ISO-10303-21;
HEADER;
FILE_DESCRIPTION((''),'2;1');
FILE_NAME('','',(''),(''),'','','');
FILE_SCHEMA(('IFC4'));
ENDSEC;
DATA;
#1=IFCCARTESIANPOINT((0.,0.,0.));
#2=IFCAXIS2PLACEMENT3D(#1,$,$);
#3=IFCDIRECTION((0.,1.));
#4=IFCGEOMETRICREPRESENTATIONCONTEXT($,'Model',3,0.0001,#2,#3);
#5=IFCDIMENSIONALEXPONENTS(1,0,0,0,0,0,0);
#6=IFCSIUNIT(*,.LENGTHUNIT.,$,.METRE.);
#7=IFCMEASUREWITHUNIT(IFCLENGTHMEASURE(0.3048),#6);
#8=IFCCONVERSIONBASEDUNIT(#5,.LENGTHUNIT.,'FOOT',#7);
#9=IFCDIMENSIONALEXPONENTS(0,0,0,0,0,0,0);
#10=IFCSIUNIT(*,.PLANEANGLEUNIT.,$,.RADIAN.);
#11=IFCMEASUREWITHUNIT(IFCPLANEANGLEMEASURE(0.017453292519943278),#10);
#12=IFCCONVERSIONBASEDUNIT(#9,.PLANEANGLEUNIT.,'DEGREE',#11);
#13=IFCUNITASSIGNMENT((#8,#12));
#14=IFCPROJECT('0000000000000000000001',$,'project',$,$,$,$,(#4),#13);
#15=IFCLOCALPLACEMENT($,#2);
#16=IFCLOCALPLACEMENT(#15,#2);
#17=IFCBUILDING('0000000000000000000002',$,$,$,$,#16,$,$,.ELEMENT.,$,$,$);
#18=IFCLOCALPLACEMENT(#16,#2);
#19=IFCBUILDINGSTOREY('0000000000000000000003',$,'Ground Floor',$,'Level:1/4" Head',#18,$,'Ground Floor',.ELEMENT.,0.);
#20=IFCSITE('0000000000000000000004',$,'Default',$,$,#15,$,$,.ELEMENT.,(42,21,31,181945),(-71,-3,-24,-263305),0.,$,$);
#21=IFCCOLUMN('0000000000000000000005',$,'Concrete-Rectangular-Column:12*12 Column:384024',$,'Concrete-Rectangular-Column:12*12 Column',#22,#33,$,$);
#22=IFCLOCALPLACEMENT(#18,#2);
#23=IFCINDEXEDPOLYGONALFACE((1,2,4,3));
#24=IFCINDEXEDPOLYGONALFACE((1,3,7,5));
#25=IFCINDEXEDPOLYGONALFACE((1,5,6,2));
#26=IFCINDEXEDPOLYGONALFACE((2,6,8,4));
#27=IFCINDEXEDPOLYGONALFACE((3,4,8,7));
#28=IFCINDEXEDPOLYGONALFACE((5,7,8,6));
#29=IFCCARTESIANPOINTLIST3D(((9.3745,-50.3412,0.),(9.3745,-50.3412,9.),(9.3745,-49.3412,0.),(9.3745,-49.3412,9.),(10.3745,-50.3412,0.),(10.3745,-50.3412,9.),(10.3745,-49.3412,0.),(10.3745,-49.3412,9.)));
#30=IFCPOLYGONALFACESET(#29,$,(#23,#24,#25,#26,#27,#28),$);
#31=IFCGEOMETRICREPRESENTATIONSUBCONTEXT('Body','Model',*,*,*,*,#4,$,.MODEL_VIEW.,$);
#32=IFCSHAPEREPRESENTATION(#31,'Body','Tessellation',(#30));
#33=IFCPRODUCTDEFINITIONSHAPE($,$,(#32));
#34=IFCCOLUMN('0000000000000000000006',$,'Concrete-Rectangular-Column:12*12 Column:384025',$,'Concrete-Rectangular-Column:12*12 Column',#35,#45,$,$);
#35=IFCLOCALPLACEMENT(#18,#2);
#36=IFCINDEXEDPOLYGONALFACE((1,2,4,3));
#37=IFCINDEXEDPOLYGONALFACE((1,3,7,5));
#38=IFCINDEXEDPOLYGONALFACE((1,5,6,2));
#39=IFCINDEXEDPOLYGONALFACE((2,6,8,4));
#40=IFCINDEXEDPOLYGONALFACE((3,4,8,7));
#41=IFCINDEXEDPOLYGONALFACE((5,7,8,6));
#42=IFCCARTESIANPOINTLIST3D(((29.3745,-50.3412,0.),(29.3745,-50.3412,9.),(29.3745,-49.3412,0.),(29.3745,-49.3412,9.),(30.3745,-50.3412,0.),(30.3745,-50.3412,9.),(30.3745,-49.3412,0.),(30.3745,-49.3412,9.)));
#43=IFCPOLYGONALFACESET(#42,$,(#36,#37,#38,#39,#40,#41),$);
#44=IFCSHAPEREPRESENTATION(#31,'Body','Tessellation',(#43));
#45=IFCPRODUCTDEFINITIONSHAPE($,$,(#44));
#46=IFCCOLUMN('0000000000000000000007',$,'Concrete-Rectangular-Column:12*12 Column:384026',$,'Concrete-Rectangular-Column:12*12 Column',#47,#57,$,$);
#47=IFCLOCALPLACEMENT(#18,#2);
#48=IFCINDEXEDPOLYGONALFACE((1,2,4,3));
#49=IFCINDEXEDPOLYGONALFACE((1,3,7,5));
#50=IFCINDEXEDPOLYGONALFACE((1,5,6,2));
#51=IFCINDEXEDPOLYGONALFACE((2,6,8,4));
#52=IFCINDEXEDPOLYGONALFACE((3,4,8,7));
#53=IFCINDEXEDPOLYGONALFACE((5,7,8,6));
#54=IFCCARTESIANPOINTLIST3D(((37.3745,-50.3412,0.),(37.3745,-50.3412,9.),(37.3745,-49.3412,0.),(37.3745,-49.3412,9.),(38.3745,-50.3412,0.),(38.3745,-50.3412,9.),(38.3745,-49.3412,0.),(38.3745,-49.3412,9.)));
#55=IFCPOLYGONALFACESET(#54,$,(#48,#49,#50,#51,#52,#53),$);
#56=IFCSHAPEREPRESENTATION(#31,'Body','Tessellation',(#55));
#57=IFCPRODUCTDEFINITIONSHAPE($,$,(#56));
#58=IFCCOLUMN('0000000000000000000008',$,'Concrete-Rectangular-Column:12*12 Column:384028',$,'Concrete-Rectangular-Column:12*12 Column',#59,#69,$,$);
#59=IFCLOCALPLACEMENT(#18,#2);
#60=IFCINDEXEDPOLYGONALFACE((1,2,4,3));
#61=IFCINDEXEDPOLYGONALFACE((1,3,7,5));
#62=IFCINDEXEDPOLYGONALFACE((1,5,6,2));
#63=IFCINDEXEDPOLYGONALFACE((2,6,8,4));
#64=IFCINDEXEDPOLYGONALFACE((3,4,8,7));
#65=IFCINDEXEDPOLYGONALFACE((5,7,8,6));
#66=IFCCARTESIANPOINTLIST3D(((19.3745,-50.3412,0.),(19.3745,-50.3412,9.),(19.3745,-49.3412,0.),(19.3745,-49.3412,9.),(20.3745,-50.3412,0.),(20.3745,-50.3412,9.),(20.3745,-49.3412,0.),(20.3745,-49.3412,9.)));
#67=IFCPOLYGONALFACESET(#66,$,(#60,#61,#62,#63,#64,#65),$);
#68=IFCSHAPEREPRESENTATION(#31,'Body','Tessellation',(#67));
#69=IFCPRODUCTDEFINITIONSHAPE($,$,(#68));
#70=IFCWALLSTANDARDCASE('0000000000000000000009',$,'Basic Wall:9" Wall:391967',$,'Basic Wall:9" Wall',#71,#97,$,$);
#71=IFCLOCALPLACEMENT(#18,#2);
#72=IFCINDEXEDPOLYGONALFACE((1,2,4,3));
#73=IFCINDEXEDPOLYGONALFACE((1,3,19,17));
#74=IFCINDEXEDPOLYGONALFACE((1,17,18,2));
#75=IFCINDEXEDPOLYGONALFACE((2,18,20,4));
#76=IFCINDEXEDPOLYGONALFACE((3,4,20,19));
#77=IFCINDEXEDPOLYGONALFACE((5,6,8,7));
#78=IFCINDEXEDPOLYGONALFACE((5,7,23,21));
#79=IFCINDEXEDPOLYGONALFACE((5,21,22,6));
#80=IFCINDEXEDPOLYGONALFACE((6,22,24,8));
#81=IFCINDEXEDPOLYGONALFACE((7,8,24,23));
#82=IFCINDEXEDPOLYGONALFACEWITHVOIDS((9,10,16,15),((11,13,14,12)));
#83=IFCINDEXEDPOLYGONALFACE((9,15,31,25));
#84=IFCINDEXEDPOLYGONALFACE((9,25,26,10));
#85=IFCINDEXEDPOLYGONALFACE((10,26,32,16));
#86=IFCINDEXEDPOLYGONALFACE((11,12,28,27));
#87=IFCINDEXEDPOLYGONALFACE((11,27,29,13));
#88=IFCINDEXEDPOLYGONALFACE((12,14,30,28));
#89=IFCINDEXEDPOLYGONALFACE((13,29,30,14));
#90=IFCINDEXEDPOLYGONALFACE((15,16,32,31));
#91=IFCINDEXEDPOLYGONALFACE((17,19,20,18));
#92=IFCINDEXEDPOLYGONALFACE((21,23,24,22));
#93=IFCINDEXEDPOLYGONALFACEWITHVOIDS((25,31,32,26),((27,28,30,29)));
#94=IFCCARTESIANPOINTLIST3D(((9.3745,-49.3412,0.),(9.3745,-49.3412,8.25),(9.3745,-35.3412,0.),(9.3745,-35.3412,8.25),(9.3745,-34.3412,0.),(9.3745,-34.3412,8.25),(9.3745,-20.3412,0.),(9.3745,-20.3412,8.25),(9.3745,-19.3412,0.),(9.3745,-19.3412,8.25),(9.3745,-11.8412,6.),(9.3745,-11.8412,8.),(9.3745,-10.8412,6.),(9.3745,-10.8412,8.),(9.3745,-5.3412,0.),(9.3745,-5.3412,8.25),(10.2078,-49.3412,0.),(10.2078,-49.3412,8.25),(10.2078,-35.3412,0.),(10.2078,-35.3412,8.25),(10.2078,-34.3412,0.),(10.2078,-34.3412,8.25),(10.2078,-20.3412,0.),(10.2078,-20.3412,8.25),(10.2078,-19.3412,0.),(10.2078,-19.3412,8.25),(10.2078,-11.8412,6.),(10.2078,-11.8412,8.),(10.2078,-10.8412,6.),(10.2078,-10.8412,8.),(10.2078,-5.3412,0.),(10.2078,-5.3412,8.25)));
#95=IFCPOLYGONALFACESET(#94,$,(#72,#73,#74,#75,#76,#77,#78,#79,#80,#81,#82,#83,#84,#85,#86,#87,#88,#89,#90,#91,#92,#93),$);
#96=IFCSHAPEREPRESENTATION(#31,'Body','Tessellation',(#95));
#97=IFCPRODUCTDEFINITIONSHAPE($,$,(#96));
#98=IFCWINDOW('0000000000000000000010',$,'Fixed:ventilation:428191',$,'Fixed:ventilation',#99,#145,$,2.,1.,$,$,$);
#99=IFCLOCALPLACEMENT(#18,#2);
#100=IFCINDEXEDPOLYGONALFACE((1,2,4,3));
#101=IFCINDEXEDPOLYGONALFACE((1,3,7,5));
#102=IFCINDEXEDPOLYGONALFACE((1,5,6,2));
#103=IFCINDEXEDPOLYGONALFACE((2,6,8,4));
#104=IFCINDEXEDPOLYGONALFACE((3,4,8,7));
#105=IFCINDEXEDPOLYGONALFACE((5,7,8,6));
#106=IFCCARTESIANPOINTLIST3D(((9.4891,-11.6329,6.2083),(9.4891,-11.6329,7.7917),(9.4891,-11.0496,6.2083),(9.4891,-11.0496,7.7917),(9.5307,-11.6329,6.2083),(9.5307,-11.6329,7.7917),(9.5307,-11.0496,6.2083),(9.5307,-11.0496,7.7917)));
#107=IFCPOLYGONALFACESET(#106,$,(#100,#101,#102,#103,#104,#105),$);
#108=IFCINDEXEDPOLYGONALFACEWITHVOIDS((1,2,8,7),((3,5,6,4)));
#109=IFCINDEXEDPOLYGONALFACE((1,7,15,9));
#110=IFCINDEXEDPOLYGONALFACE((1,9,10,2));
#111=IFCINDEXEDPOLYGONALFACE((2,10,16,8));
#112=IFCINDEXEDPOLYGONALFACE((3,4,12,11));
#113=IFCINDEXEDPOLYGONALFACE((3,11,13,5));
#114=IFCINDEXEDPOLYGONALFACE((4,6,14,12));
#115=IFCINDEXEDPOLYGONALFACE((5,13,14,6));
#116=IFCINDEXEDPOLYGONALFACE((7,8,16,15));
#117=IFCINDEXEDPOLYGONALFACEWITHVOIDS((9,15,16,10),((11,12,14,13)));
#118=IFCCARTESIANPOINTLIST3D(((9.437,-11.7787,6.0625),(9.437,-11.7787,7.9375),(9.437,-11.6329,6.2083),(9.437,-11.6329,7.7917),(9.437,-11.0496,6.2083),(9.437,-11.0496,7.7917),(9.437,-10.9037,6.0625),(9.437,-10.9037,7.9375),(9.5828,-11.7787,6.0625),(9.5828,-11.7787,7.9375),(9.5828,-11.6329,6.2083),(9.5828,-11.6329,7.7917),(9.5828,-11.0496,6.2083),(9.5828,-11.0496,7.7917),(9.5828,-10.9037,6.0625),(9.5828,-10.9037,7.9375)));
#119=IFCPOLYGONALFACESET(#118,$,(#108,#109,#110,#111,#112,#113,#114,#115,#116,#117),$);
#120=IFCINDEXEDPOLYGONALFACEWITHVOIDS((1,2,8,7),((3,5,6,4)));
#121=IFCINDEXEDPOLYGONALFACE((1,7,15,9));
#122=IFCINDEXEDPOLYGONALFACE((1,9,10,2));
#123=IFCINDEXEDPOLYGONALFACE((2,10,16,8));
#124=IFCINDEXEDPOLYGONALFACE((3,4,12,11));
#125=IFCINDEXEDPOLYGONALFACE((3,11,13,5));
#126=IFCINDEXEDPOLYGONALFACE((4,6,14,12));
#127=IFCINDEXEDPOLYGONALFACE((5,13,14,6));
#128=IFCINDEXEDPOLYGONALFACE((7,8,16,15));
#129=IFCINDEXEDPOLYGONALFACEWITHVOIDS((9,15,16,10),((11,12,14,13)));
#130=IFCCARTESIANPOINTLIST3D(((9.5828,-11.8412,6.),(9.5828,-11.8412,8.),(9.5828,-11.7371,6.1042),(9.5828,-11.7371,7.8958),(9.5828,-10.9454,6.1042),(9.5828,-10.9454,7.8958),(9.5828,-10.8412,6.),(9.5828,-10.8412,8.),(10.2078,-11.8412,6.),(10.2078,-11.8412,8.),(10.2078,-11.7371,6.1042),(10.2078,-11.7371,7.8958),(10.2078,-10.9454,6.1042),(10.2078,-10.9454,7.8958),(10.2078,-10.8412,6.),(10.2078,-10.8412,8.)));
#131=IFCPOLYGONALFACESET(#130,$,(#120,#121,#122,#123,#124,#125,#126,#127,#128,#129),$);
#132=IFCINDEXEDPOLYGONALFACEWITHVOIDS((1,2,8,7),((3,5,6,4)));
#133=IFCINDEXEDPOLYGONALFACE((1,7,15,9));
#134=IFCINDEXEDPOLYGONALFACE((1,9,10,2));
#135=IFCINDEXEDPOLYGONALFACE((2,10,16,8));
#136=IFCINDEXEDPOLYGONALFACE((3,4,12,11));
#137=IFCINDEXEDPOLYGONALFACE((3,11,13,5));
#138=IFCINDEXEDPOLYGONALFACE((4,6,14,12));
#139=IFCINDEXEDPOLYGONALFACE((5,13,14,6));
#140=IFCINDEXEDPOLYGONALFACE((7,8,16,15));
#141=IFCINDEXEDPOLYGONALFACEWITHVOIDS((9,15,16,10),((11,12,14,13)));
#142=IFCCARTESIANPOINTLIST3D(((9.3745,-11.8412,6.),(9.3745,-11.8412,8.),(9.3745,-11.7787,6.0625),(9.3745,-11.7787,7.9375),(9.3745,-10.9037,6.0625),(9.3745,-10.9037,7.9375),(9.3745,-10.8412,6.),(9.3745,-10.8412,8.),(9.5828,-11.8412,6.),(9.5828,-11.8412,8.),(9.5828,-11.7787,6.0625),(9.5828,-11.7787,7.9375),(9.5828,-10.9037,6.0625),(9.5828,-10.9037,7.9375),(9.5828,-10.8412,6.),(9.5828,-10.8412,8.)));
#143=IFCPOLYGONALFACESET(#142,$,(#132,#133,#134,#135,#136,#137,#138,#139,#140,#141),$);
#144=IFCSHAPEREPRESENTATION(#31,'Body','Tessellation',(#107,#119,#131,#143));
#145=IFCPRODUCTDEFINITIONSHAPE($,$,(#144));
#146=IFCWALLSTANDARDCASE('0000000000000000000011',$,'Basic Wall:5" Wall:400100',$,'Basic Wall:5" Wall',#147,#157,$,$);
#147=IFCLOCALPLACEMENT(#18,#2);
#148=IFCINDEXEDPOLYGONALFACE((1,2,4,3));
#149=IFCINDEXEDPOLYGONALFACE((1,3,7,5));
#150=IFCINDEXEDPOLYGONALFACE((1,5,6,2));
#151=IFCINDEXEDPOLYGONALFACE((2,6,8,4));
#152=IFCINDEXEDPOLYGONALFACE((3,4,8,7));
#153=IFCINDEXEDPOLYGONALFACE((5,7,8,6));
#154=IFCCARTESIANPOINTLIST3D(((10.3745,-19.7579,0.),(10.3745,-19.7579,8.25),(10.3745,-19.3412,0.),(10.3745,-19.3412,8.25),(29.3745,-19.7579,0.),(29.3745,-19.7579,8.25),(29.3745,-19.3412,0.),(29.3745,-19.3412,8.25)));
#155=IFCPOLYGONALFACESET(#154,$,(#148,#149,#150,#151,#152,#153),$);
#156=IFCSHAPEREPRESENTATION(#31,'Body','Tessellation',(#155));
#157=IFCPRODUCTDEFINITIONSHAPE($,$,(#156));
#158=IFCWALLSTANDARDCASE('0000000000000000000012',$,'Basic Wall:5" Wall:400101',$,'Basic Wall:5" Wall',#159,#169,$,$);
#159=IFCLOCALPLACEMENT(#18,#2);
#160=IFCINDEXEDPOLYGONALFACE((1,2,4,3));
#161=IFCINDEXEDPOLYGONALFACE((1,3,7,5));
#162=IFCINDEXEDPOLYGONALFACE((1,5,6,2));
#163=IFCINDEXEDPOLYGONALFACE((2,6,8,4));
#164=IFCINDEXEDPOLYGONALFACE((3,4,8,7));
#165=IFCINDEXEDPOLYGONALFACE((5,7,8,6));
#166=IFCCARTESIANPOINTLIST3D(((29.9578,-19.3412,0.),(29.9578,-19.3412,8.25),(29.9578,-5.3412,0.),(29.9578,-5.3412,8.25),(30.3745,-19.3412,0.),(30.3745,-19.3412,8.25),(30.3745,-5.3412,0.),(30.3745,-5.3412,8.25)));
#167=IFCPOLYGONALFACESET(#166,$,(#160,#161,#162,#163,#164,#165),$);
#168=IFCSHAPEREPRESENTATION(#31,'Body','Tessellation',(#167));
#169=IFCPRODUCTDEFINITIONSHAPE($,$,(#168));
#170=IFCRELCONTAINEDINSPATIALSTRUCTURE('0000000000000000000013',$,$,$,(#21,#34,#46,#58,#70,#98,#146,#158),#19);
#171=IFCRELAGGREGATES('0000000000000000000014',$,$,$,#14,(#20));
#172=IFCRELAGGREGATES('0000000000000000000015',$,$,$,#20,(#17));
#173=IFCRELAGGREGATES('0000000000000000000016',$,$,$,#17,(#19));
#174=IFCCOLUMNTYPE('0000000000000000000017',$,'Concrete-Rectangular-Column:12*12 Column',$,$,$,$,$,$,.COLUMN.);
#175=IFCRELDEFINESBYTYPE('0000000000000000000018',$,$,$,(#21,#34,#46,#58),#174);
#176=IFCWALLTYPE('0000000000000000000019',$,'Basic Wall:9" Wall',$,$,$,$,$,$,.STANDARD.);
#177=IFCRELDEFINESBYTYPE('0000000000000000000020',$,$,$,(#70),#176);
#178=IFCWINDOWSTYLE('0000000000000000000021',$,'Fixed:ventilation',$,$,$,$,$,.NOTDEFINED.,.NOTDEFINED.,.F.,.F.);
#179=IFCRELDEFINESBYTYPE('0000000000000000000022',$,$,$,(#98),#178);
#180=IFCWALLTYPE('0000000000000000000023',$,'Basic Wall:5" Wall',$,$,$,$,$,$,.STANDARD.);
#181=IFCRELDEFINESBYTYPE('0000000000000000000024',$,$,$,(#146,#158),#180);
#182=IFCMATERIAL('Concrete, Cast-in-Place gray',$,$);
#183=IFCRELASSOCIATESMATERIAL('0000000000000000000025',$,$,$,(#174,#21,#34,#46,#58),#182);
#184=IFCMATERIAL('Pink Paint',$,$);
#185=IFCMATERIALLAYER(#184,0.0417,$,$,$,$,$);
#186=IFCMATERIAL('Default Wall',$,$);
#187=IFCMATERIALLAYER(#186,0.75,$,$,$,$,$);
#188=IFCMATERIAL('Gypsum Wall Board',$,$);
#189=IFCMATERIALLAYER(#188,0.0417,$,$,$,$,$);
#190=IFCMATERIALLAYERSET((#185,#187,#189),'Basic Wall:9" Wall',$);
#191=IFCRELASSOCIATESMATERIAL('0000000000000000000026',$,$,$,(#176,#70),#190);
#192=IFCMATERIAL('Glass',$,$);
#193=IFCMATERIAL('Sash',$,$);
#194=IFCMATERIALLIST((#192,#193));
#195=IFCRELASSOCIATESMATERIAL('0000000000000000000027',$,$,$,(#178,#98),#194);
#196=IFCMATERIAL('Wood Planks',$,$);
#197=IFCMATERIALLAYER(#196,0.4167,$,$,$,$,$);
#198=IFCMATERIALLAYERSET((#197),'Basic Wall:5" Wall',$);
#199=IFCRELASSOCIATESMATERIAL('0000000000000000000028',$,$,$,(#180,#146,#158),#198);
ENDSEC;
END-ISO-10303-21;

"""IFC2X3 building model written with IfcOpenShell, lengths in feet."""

from ifc_helpers import new_model, entity, si_unit, converted_unit, direction, frame, frame_2d, origin, origin_2d_with_axis, place, context, subcontext, project, spatial, polyline, rectangle, outline, extrude, clip, bounded_halfspace, source, transform, mapped, material, material_list, layer, layer_set, layer_usage, type_object, type_shapes, element, fill, save


model = new_model("IFC2X3")

# Units and contexts
model_context = context("Model", 3, precision=0.0001, world=origin(), true_north=direction((0.0, 1.0)))
body_context = subcontext(model_context, "Body", "Model", "MODEL_VIEW")
ifc_project = project(units=[converted_unit("LENGTHUNIT", "FOOT", entity("IfcLengthMeasure", 0.3048), si_unit("LENGTHUNIT", "METRE"), dimensions=[1, 0, 0, 0, 0, 0, 0]), converted_unit("PLANEANGLEUNIT", "DEGREE", entity("IfcPlaneAngleMeasure", 0.017453292519943278), si_unit("PLANEANGLEUNIT", "RADIAN"), dimensions=[0, 0, 0, 0, 0, 0, 0])], contexts=[model_context])

# Site, building, storey
site_placement = place(None, origin())
site = spatial("IfcSite", under=ifc_project, at=site_placement, Name="Default", CompositionType="ELEMENT", RefLatitude=(42, 21, 31, 181945), RefLongitude=(-71, -3, -24, -263305), RefElevation=0.0)
building_placement = place(site_placement, origin())
building = spatial("IfcBuilding", under=site, at=building_placement, CompositionType="ELEMENT")
storey_placement = place(building_placement, origin())
storey = spatial("IfcBuildingStorey", under=building, at=storey_placement, Name="Ground Floor", ObjectType="Level:1/4\" Head", LongName="Ground Floor", CompositionType="ELEMENT", Elevation=0.0)

# Columns
ifc_material_1 = material(Name="Concrete, Cast-in-Place gray")
column_type = type_object("IfcColumnType", Name="Concrete-Rectangular-Column:12*12 Column", PredefinedType="COLUMN", material=ifc_material_1)
shared_shape_1 = source(origin(), body_context, "Body", "SweptSolid", [
    extrude(rectangle(XDim=1.0, YDim=1.0, at=origin_2d_with_axis()), frame((0.0, 0.0, 0.0), z_axis=(0.0, 0.0, 1.0), x_axis=(-1.0, 0.0, 0.0)), (0.0, 0.0, 1.0), 9.0),
])
type_shapes(column_type, [shared_shape_1])
for number, where, name in (
    (1, (9.8745, -49.8412, 0.0), "Concrete-Rectangular-Column:12*12 Column:384024"),
    (2, (29.8745, -49.8412, 0.0), "Concrete-Rectangular-Column:12*12 Column:384025"),
    (3, (37.8745, -49.8412, 0.0), "Concrete-Rectangular-Column:12*12 Column:384026"),
    (4, (19.8745, -49.8412, 0.0), "Concrete-Rectangular-Column:12*12 Column:384028"),
):
    element("IfcColumn", number, at=place(storey_placement, frame(where)), inside=storey, type_object=column_type, material=ifc_material_1, Name=name, ObjectType="Concrete-Rectangular-Column:12*12 Column", context=body_context, shape_type="MappedRepresentation", body=[
        mapped(shared_shape_1, transform((0.0, 0.0, 0.0), scale=1.0)),
    ])

# Wall, openings, window
ifc_material_2 = material(Name="Pink Paint")
ifc_layer_1 = layer(ifc_material_2, 0.0417)
ifc_material_3 = material(Name="Default Wall")
ifc_layer_2 = layer(ifc_material_3, 0.75)
ifc_material_4 = material(Name="Gypsum Wall Board")
ifc_layer_3 = layer(ifc_material_4, 0.0417)
ifc_layer_set_1 = layer_set([ifc_layer_1, ifc_layer_2, ifc_layer_3], Name="Basic Wall:9\" Wall")
ifc_layer_usage_1 = layer_usage(ifc_layer_set_1, "AXIS2", "NEGATIVE", 0.4167)
wall_type_1 = type_object("IfcWallType", Name="Basic Wall:9\" Wall", PredefinedType="STANDARD", material=ifc_layer_set_1)
wall_1_placement = place(storey_placement, frame((9.7911, -49.3412, 0.0), z_axis=(0.0, 0.0, 1.0), x_axis=(0.0, 1.0, 0.0)))
wall_1 = element("IfcWallStandardCase", 5, at=wall_1_placement, inside=storey, type_object=wall_type_1, material=ifc_layer_usage_1, Name="Basic Wall:9\" Wall:391967", ObjectType="Basic Wall:9\" Wall", context=body_context, shape_type="Clipping", body=[
    clip(clip(clip(clip(clip(extrude(rectangle(XDim=44.0, YDim=0.8333, at=frame_2d((22.0, 0.0), x_axis=(-1.0, 0.0))), origin(), (0.0, 0.0, 1.0), 8.25), bounded_halfspace(frame((0.0, 0.4167, 0.0), z_axis=(1.0, 0.0, 0.0), x_axis=(0.0, 0.0, -1.0)), True, frame((0.0, 0.4167, 0.0), z_axis=(1.0, 0.0, 0.0), x_axis=(0.0, 0.0, -1.0)), polyline([(0.0, 0.0), (-8.25, 0.0), (-8.25, -0.8333), (0.0, -0.8333), (0.0, 0.0)]))), bounded_halfspace(frame((44.0, -0.4167, 0.0), z_axis=(-1.0, 0.0, 0.0), x_axis=(0.0, 0.0, -1.0)), True, frame((44.0, -0.4167, 0.0), z_axis=(-1.0, 0.0, 0.0), x_axis=(0.0, 0.0, -1.0)), polyline([(0.0, 0.0), (-8.25, 0.0), (-8.25, -0.8333), (0.0, -0.8333), (0.0, 0.0)]))), bounded_halfspace(frame((30.0, -0.4167, 8.25), z_axis=(0.0, 0.0, 1.0), x_axis=(0.0, -1.0, 0.0)), False, frame((30.0, -0.4167, 8.25), z_axis=(0.0, 0.0, 1.0), x_axis=(0.0, -1.0, 0.0)), polyline([(0.0, 0.0), (0.0, 14.0), (-0.8333, 14.0), (-0.8333, 0.0), (0.0, 0.0)]))), bounded_halfspace(frame((15.0, -0.4167, 8.25), z_axis=(0.0, 0.0, 1.0), x_axis=(0.0, -1.0, 0.0)), False, frame((15.0, -0.4167, 8.25), z_axis=(0.0, 0.0, 1.0), x_axis=(0.0, -1.0, 0.0)), polyline([(0.0, 0.0), (0.0, 14.0), (-0.8333, 14.0), (-0.8333, 0.0), (0.0, 0.0)]))), bounded_halfspace(frame((0.0, -0.4167, 8.25), z_axis=(0.0, 0.0, 1.0), x_axis=(0.0, -1.0, 0.0)), False, frame((0.0, -0.4167, 8.25), z_axis=(0.0, 0.0, 1.0), x_axis=(0.0, -1.0, 0.0)), polyline([(0.0, 0.0), (0.0, 14.0), (-0.8333, 14.0), (-0.8333, 0.0), (0.0, 0.0)]))),
])
opening_1_placement = place(storey_placement, frame((9.7911, -49.3412, 0.0), z_axis=(0.0, 0.0, 1.0), x_axis=(0.0, 1.0, 0.0)))
element("IfcOpeningElement", 6, at=opening_1_placement, cuts=wall_1, ObjectType="Opening", context=body_context, shape_type="SweptSolid", body=[
    extrude(rectangle(XDim=8.25, YDim=0.8333, at=frame_2d((0.0, 0.0), x_axis=(0.0, 1.0))), frame((29.0, 0.0, 4.125), z_axis=(1.0, 0.0, 0.0), x_axis=(0.0, 1.0, 0.0)), (0.0, 0.0, 1.0), 1.0),
])
opening_2_placement = place(storey_placement, frame((9.7911, -49.3412, 0.0), z_axis=(0.0, 0.0, 1.0), x_axis=(0.0, 1.0, 0.0)))
element("IfcOpeningElement", 7, at=opening_2_placement, cuts=wall_1, ObjectType="Opening", context=body_context, shape_type="SweptSolid", body=[
    extrude(rectangle(XDim=8.25, YDim=0.8333, at=frame_2d((0.0, 0.0), x_axis=(0.0, 1.0))), frame((14.0, 0.0, 4.125), z_axis=(1.0, 0.0, 0.0), x_axis=(0.0, 1.0, 0.0)), (0.0, 0.0, 1.0), 1.0),
])
opening_3_placement = place(wall_1_placement, frame((37.5, -0.4167, 6.0)))
opening_3 = element("IfcOpeningElement", 8, at=opening_3_placement, cuts=wall_1, ObjectType="Opening", context=body_context, shape_type="SweptSolid", body=[
    extrude(rectangle(XDim=2.0, YDim=1.0, at=frame_2d((1.0, 0.5), x_axis=(-1.0, 0.0))), frame((0.0, 0.0, 0.0), z_axis=(0.0, 1.0, 0.0), x_axis=(0.0, 0.0, 1.0)), (0.0, 0.0, 1.0), 0.8333),
])
ifc_material_5 = material(Name="Glass")
ifc_material_6 = material(Name="Sash")
ifc_material_list_1 = material_list([ifc_material_5, ifc_material_6])
window_style = type_object("IfcWindowStyle", Name="Fixed:ventilation", ConstructionType="NOTDEFINED", OperationType="NOTDEFINED", ParameterTakesPrecedence=False, Sizeable=False, material=ifc_material_list_1)
shared_shape_2 = source(origin(), body_context, "Body", "SweptSolid", [
    extrude(rectangle(XDim=0.0417, YDim=0.5833, at=origin_2d_with_axis()), frame((0.5, 0.6979, 0.2083), z_axis=(0.0, 0.0, 1.0), x_axis=(0.0, 1.0, 0.0)), (0.0, 0.0, 1.0), 1.5833),
    extrude(outline(polyline([(-0.4375, -0.9375), (0.4375, -0.9375), (0.4375, 0.9375), (-0.4375, 0.9375), (-0.4375, -0.9375)]), holes=[polyline([(-0.2917, -0.7917), (-0.2917, 0.7917), (0.2917, 0.7917), (0.2917, -0.7917), (-0.2917, -0.7917)])]), frame((0.5, 0.625, 1.0), z_axis=(0.0, 1.0, 0.0), x_axis=(1.0, 0.0, 0.0)), (0.0, 0.0, 1.0), 0.1458),
    extrude(outline(polyline([(-0.5, -1.0), (0.5, -1.0), (0.5, 1.0), (-0.5, 1.0), (-0.5, -1.0)]), holes=[polyline([(-0.3958, -0.8958), (-0.3958, 0.8958), (0.3958, 0.8958), (0.3958, -0.8958), (-0.3958, -0.8958)])]), frame((0.5, 0.0, 1.0), z_axis=(0.0, 1.0, 0.0), x_axis=(1.0, 0.0, 0.0)), (0.0, 0.0, 1.0), 0.625),
    extrude(outline(polyline([(-1.0, -0.5), (1.0, -0.5), (1.0, 0.5), (-1.0, 0.5), (-1.0, -0.5)]), holes=[polyline([(-0.9375, -0.4375), (-0.9375, 0.4375), (0.9375, 0.4375), (0.9375, -0.4375), (-0.9375, -0.4375)])]), frame((0.5, 0.625, 1.0), z_axis=(0.0, 1.0, 0.0), x_axis=(0.0, 0.0, -1.0)), (0.0, 0.0, 1.0), 0.2083),
])
type_shapes(window_style, [shared_shape_2])
window_placement = place(opening_3_placement, origin())
window = element("IfcWindow", 9, at=window_placement, inside=storey, type_object=window_style, material=ifc_material_list_1, Name="Fixed:ventilation:428191", ObjectType="Fixed:ventilation", OverallHeight=2.0, OverallWidth=1.0, context=body_context, shape_type="MappedRepresentation", body=[
    mapped(shared_shape_2, transform((0.0, 0.0, 0.0), scale=1.0)),
])
fill(opening_3, window)

# Walls
ifc_material_7 = material(Name="Wood Planks")
ifc_layer_4 = layer(ifc_material_7, 0.4167)
ifc_layer_set_2 = layer_set([ifc_layer_4], Name="Basic Wall:5\" Wall")
ifc_layer_usage_2 = layer_usage(ifc_layer_set_2, "AXIS2", "NEGATIVE", 0.2083)
wall_type_2 = type_object("IfcWallType", Name="Basic Wall:5\" Wall", PredefinedType="STANDARD", material=ifc_layer_set_2)
wall_2_placement = place(storey_placement, frame((10.3745, -19.5496, 0.0)))
element("IfcWallStandardCase", 10, at=wall_2_placement, inside=storey, type_object=wall_type_2, material=ifc_layer_usage_2, Name="Basic Wall:5\" Wall:400100", ObjectType="Basic Wall:5\" Wall", context=body_context, shape_type="SweptSolid", body=[
    extrude(rectangle(XDim=19.0, YDim=0.4167, at=frame_2d((9.5, 0.0), x_axis=(-1.0, 0.0))), origin(), (0.0, 0.0, 1.0), 8.25),
])
wall_3_placement = place(storey_placement, frame((30.1661, -19.3412, 0.0), z_axis=(0.0, 0.0, 1.0), x_axis=(0.0, 1.0, 0.0)))
element("IfcWallStandardCase", 11, at=wall_3_placement, inside=storey, type_object=wall_type_2, material=ifc_layer_usage_2, Name="Basic Wall:5\" Wall:400101", ObjectType="Basic Wall:5\" Wall", context=body_context, shape_type="SweptSolid", body=[
    extrude(rectangle(XDim=14.0, YDim=0.4167, at=frame_2d((7.0, 0.0), x_axis=(-1.0, 0.0))), origin(), (0.0, 0.0, 1.0), 8.25),
])

save(model, "model.ifc")
